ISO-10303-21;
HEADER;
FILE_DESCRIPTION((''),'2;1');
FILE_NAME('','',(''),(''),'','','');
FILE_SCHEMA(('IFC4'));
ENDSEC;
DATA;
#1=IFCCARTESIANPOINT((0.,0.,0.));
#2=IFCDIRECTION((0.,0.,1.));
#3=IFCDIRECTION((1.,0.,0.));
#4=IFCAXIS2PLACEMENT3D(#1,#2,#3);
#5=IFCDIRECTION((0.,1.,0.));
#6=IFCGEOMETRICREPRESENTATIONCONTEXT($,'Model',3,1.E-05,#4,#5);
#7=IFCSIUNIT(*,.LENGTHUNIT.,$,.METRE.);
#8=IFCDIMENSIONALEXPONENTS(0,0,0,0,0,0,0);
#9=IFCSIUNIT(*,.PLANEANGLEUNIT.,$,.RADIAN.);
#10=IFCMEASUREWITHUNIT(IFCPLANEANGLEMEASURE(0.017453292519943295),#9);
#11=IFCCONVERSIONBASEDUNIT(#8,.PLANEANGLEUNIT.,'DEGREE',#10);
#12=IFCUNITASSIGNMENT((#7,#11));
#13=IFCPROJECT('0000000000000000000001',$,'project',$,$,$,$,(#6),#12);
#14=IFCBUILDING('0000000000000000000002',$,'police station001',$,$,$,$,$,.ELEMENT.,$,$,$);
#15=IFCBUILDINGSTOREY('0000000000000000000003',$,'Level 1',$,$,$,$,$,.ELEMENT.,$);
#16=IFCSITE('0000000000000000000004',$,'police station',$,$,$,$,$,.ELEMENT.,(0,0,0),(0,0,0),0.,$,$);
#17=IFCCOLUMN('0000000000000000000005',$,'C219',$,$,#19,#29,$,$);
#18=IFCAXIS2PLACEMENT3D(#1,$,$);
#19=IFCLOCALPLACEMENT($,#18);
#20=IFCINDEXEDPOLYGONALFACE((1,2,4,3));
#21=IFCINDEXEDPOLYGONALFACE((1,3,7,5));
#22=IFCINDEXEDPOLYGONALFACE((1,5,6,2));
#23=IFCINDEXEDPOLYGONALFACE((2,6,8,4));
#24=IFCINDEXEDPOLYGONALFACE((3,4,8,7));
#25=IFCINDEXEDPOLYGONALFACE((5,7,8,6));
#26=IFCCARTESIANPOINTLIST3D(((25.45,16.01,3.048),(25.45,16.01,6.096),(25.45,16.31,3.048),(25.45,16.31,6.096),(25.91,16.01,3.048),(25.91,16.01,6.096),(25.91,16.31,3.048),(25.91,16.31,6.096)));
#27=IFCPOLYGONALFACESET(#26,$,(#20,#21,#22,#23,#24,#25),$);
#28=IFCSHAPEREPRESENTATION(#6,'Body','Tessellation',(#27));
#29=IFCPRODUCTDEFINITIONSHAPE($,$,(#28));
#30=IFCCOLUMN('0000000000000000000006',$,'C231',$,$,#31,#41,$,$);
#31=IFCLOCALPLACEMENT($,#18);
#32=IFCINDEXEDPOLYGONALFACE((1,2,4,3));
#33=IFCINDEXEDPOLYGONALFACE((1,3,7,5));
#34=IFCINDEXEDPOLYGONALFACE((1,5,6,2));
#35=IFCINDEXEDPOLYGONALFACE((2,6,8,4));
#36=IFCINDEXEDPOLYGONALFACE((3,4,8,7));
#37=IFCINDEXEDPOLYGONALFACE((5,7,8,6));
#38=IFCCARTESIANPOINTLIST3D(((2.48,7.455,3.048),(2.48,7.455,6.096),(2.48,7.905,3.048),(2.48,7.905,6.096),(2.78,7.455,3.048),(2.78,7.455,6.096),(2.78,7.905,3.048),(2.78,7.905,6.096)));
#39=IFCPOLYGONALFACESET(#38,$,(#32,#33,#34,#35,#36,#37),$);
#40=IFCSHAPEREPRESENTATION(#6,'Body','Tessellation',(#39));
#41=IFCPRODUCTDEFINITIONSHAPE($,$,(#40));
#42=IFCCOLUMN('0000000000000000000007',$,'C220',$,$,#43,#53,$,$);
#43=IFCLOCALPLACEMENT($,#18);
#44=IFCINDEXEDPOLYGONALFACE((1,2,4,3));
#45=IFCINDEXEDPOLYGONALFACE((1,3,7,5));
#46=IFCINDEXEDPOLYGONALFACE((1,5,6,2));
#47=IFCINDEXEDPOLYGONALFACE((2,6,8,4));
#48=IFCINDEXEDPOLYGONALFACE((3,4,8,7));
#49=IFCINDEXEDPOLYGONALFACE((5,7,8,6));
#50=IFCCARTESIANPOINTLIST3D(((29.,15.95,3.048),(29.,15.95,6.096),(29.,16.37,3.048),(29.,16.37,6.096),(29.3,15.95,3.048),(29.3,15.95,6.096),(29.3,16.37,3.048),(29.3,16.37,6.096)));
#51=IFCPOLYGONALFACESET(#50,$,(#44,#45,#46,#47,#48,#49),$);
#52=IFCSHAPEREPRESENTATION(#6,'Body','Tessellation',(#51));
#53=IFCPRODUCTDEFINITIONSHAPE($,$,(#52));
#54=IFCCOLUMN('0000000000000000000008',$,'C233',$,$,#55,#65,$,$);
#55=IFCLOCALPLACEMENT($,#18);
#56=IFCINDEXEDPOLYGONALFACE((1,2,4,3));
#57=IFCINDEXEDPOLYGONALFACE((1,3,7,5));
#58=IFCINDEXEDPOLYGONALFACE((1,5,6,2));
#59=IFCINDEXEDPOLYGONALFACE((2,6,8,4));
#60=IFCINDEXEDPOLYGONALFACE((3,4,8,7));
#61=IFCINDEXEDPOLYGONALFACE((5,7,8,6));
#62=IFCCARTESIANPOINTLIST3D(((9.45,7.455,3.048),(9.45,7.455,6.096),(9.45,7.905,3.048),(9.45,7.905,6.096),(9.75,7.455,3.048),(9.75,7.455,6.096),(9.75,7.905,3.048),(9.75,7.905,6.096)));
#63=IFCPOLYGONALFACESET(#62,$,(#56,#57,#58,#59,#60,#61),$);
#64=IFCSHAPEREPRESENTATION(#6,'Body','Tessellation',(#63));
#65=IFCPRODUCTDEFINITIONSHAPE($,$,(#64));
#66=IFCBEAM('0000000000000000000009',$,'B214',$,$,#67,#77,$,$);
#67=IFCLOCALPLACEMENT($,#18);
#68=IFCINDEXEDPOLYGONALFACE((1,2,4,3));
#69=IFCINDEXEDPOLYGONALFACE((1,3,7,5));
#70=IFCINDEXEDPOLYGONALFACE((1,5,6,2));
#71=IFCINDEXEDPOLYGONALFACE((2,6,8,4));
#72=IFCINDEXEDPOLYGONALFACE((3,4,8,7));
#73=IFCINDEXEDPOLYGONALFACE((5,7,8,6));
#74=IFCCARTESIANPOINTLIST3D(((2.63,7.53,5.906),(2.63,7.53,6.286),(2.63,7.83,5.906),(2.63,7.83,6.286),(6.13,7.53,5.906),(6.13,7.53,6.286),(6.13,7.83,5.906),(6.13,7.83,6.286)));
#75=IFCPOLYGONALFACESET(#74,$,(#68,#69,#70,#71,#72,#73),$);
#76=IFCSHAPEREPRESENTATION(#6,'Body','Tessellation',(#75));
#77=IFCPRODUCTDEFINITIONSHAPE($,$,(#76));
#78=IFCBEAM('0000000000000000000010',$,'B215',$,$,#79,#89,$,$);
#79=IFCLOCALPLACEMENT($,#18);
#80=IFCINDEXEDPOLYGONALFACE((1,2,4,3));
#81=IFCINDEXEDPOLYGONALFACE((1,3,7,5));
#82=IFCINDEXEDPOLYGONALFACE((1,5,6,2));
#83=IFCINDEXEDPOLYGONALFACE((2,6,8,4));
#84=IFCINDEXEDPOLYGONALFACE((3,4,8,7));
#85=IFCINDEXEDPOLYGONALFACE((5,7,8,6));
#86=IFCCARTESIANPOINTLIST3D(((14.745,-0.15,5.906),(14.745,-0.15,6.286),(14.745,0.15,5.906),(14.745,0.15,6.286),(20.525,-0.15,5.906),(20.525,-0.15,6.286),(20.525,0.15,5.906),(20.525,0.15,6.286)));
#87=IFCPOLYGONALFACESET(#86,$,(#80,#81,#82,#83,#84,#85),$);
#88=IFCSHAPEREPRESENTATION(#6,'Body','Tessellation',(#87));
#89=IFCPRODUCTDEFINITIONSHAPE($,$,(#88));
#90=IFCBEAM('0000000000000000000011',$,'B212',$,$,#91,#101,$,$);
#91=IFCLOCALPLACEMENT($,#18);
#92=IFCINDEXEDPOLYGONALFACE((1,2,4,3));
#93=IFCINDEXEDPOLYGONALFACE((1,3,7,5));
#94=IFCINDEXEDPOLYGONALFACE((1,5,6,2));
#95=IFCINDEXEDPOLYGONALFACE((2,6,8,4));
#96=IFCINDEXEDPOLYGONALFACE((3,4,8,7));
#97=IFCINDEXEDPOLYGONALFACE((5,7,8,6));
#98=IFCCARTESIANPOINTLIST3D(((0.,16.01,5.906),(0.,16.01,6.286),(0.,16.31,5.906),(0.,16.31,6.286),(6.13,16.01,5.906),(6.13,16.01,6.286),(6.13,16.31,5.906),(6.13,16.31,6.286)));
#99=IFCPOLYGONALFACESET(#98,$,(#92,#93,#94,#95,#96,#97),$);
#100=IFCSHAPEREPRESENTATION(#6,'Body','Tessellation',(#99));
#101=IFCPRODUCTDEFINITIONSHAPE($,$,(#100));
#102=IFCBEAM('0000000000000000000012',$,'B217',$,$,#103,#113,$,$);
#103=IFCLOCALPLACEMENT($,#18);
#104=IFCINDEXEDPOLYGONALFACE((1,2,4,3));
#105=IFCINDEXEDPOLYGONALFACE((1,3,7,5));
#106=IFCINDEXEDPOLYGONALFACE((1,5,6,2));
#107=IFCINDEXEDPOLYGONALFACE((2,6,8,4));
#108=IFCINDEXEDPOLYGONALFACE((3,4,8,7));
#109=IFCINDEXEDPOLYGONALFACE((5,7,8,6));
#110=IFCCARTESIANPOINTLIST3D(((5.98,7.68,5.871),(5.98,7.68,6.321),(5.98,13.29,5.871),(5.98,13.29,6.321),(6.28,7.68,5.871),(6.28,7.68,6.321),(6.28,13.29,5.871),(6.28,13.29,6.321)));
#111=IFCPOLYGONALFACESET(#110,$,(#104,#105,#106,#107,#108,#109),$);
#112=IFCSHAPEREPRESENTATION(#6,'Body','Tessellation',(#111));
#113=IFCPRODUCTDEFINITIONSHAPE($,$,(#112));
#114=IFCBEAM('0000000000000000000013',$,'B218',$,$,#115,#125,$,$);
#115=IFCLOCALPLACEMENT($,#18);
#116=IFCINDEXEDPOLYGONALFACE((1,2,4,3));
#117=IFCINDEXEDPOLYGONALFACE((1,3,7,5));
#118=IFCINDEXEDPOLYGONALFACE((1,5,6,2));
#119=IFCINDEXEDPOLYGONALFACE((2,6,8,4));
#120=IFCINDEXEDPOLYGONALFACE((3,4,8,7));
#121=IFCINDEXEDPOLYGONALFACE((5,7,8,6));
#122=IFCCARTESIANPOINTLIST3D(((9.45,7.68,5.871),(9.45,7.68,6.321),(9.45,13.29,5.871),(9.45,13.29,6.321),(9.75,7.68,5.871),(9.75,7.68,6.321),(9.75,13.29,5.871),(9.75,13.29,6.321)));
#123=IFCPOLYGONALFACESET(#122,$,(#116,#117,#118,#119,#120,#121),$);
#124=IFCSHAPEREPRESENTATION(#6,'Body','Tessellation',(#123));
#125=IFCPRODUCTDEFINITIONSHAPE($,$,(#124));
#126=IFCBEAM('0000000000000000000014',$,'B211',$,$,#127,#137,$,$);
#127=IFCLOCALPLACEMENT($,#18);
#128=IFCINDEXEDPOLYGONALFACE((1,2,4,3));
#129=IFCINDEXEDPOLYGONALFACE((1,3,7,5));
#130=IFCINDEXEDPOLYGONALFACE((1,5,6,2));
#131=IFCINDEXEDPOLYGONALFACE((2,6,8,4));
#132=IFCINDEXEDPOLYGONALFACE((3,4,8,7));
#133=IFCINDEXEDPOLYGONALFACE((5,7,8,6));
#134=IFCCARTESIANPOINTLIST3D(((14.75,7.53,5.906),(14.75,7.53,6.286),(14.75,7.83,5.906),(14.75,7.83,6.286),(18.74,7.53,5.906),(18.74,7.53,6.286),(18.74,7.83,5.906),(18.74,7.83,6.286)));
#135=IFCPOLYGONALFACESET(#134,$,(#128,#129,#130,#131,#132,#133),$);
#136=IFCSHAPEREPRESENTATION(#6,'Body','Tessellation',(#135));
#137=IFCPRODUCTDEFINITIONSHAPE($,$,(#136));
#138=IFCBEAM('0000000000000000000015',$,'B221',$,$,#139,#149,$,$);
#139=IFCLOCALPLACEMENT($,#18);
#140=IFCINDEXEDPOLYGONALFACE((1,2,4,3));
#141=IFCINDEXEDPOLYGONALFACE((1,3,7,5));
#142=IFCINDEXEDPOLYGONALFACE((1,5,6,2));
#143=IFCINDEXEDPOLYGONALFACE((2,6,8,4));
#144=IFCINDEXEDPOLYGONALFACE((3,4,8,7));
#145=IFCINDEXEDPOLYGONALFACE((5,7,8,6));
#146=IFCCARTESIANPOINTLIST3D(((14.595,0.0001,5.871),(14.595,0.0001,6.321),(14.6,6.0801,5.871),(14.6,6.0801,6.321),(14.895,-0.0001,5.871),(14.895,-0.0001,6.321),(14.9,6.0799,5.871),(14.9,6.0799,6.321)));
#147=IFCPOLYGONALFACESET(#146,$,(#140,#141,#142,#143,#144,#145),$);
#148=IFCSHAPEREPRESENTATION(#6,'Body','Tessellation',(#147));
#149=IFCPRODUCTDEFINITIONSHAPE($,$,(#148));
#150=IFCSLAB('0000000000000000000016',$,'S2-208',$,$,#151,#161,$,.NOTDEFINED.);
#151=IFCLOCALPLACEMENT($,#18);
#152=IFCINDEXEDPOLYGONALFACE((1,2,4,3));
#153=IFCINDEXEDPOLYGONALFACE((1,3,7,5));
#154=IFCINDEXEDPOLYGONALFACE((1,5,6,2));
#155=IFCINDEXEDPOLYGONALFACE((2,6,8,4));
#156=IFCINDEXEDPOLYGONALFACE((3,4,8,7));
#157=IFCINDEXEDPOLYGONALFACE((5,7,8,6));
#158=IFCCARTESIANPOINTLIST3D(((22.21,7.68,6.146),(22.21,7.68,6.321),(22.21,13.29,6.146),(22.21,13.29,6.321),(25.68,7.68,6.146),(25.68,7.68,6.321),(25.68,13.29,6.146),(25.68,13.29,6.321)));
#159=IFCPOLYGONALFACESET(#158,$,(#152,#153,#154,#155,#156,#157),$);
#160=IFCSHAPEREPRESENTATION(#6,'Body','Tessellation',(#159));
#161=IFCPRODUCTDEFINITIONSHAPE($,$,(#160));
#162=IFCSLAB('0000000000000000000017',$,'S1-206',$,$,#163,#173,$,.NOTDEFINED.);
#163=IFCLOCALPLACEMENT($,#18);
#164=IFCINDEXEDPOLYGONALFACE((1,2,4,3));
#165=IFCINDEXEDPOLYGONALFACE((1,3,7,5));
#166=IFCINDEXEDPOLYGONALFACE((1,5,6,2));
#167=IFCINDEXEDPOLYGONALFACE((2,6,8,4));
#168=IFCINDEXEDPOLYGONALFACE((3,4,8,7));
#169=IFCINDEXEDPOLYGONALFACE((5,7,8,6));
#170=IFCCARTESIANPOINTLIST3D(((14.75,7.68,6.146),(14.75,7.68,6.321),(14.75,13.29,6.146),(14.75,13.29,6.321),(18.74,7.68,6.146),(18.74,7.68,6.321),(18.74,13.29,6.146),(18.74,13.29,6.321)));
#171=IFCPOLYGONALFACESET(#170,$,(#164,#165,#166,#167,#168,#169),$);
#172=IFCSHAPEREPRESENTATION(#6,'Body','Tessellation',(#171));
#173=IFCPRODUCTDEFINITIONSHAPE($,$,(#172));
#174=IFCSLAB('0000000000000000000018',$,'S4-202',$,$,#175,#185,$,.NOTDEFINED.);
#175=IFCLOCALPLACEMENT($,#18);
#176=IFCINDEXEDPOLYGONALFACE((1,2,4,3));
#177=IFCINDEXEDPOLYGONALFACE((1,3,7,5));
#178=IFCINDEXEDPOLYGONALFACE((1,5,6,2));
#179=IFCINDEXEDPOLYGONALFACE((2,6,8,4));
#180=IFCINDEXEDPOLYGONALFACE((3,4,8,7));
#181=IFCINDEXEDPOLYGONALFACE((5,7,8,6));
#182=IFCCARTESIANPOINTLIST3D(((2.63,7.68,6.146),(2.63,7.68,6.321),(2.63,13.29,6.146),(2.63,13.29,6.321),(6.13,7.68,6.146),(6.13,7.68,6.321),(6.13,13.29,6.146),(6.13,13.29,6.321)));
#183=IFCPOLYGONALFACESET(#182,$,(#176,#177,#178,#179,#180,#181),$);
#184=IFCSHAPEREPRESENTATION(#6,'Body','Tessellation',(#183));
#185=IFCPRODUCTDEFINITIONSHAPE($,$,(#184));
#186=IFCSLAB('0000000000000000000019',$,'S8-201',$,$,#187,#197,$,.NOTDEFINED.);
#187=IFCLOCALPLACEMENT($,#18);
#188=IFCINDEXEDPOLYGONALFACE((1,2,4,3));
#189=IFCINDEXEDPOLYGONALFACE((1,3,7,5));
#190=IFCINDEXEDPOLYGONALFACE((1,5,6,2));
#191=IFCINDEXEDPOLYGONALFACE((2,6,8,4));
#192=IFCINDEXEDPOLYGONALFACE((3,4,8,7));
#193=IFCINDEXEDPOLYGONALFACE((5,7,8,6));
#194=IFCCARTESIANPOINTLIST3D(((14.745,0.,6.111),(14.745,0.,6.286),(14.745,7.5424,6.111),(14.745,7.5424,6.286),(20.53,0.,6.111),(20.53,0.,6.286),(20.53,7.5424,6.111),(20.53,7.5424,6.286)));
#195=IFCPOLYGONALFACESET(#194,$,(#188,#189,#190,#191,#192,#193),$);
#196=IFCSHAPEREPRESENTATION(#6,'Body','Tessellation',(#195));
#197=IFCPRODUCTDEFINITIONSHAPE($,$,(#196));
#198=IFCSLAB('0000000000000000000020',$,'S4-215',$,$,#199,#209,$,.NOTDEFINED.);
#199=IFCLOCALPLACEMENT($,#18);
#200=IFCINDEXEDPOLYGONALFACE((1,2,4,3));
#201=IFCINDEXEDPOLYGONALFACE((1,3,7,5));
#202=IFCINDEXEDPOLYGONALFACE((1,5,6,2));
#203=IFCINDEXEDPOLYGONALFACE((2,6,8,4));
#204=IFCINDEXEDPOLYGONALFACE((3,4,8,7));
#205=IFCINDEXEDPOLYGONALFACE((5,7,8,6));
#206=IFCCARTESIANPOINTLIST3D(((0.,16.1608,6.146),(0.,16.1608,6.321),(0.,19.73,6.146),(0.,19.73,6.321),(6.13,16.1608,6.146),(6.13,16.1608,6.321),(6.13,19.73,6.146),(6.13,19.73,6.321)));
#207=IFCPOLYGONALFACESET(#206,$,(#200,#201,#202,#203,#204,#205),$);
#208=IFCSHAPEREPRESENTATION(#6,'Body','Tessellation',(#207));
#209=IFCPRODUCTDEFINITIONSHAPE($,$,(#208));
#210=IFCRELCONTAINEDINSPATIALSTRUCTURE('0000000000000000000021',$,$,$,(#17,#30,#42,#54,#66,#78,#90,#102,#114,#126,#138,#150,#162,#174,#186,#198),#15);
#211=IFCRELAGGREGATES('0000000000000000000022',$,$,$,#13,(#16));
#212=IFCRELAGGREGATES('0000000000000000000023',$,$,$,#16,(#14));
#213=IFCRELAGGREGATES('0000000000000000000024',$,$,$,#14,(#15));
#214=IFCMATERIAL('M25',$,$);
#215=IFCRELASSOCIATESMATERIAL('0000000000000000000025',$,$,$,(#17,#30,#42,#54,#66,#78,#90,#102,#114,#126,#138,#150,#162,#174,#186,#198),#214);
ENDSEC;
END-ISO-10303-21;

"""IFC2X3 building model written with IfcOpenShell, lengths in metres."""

from ifc_helpers import new_model, entity, si_unit, converted_unit, direction, frame, frame_2d, origin_with_axes, place, context, project, spatial, rectangle, extrude, material, element, save


model = new_model("IFC2X3")

# Units and contexts
model_context = context("Model", 3, precision=1e-05, world=origin_with_axes(), true_north=direction((0.0, 1.0, 0.0)))
ifc_project = project(units=[si_unit("LENGTHUNIT", "METRE"), converted_unit("PLANEANGLEUNIT", "DEGREE", entity("IfcPlaneAngleMeasure", 0.017453292519943295), si_unit("PLANEANGLEUNIT", "RADIAN"), dimensions=[0, 0, 0, 0, 0, 0, 0])], contexts=[model_context])

# Site, building, storey
site = spatial("IfcSite", under=ifc_project, Name="police station", CompositionType="ELEMENT", RefLatitude=(0, 0, 0), RefLongitude=(0, 0, 0), RefElevation=0.0)
building = spatial("IfcBuilding", under=site, Name="police station001", CompositionType="ELEMENT")
storey = spatial("IfcBuildingStorey", under=building, Name="Level 1", CompositionType="ELEMENT")

# Columns
ifc_material = material(Name="M25")
placement = place(None, origin_with_axes())
element("IfcColumn", 1, at=placement, inside=storey, material=ifc_material, Name="C219", context=model_context, shape_type="SweptSolid", body=[
    extrude(rectangle(XDim=0.46, YDim=0.3, at=frame_2d((0.0, 0.0), x_axis=(1.0, 0.0, 0.0))), frame((25.68, 16.16, 3.048), z_axis=(0.0, 0.0, 1.0), x_axis=(1.0, 0.0, 0.0)), (0.0, 0.0, 1.0), 3.048),
])
element("IfcColumn", 2, at=placement, inside=storey, material=ifc_material, Name="C231", context=model_context, shape_type="SweptSolid", body=[
    extrude(rectangle(XDim=0.3, YDim=0.45, at=frame_2d((0.0, 0.0), x_axis=(1.0, 0.0, 0.0))), frame((2.63, 7.68, 3.048), z_axis=(0.0, 0.0, 1.0), x_axis=(1.0, 0.0, 0.0)), (0.0, 0.0, 1.0), 3.048),
])
element("IfcColumn", 3, at=placement, inside=storey, material=ifc_material, Name="C220", context=model_context, shape_type="SweptSolid", body=[
    extrude(rectangle(XDim=0.3, YDim=0.42, at=frame_2d((0.0, 0.0), x_axis=(1.0, 0.0, 0.0))), frame((29.15, 16.16, 3.048), z_axis=(0.0, 0.0, 1.0), x_axis=(1.0, 0.0, 0.0)), (0.0, 0.0, 1.0), 3.048),
])
element("IfcColumn", 4, at=placement, inside=storey, material=ifc_material, Name="C233", context=model_context, shape_type="SweptSolid", body=[
    extrude(rectangle(XDim=0.3, YDim=0.45, at=frame_2d((0.0, 0.0), x_axis=(1.0, 0.0, 0.0))), frame((9.6, 7.68, 3.048), z_axis=(0.0, 0.0, 1.0), x_axis=(1.0, 0.0, 0.0)), (0.0, 0.0, 1.0), 3.048),
])

# Beams
element("IfcBeam", 5, at=placement, inside=storey, material=ifc_material, Name="B214", context=model_context, shape_type="SweptSolid", body=[
    extrude(rectangle(XDim=0.3, YDim=0.38, at=frame_2d((0.0, 0.0), x_axis=(0.0, 1.0, 0.0))), frame((2.63, 7.68, 6.096), z_axis=(1.0, 0.0, 0.0), x_axis=(0.0, 0.0, -1.0)), (0.0, 0.0, 1.0), 3.5),
])
element("IfcBeam", 6, at=placement, inside=storey, material=ifc_material, Name="B215", context=model_context, shape_type="SweptSolid", body=[
    extrude(rectangle(XDim=0.3, YDim=0.38, at=frame_2d((0.0, 0.0), x_axis=(0.0, 1.0, 0.0))), frame((14.745, 0.0, 6.096), z_axis=(1.0, 0.0, 0.0), x_axis=(0.0, 0.0, -1.0)), (0.0, 0.0, 1.0), 5.78),
])
element("IfcBeam", 7, at=placement, inside=storey, material=ifc_material, Name="B212", context=model_context, shape_type="SweptSolid", body=[
    extrude(rectangle(XDim=0.3, YDim=0.38, at=frame_2d((0.0, 0.0), x_axis=(0.0, 1.0, 0.0))), frame((6.13, 16.16, 6.096), z_axis=(-1.0, 0.0, 0.0), x_axis=(0.0, 0.0, -1.0)), (0.0, 0.0, 1.0), 6.13),
])
element("IfcBeam", 8, at=placement, inside=storey, material=ifc_material, Name="B217", context=model_context, shape_type="SweptSolid", body=[
    extrude(rectangle(XDim=0.3, YDim=0.45, at=frame_2d((0.0, 0.0), x_axis=(0.0, 1.0, 0.0))), frame((6.13, 7.68, 6.096), z_axis=(0.0, 1.0, 0.0), x_axis=(0.0, 0.0, -1.0)), (0.0, 0.0, 1.0), 5.61),
])
element("IfcBeam", 9, at=placement, inside=storey, material=ifc_material, Name="B218", context=model_context, shape_type="SweptSolid", body=[
    extrude(rectangle(XDim=0.3, YDim=0.45, at=frame_2d((0.0, 0.0), x_axis=(0.0, 1.0, 0.0))), frame((9.6, 7.68, 6.096), z_axis=(0.0, 1.0, 0.0), x_axis=(0.0, 0.0, -1.0)), (0.0, 0.0, 1.0), 5.61),
])
element("IfcBeam", 10, at=placement, inside=storey, material=ifc_material, Name="B211", context=model_context, shape_type="SweptSolid", body=[
    extrude(rectangle(XDim=0.3, YDim=0.38, at=frame_2d((0.0, 0.0), x_axis=(0.0, 1.0, 0.0))), frame((14.75, 7.68, 6.096), z_axis=(1.0, 0.0, 0.0), x_axis=(0.0, 0.0, -1.0)), (0.0, 0.0, 1.0), 3.99),
])
element("IfcBeam", 11, at=placement, inside=storey, material=ifc_material, Name="B221", context=model_context, shape_type="SweptSolid", body=[
    extrude(rectangle(XDim=0.3, YDim=0.45, at=frame_2d((0.0, 0.0), x_axis=(0.0, 1.0, 0.0))), frame((14.745, 0.0, 6.096), z_axis=(0.000822, 1.0, 0.0), x_axis=(0.0, 0.0, -1.0)), (0.0, 0.0, 1.0), 6.08),
])

# Slabs
element("IfcSlab", 12, at=placement, inside=storey, material=ifc_material, Name="S2-208", PredefinedType="NOTDEFINED", context=model_context, shape_type="SweptSolid", body=[
    extrude(rectangle(XDim=3.47, YDim=5.61, at=frame_2d((0.0, 0.0), x_axis=(1.0, 0.0, 0.0))), frame((23.945, 10.485, 6.146), z_axis=(0.0, 0.0, 1.0), x_axis=(1.0, 0.0, 0.0)), (0.0, 0.0, 1.0), 0.175),
])
element("IfcSlab", 13, at=placement, inside=storey, material=ifc_material, Name="S1-206", PredefinedType="NOTDEFINED", context=model_context, shape_type="SweptSolid", body=[
    extrude(rectangle(XDim=3.99, YDim=5.61, at=frame_2d((0.0, 0.0), x_axis=(1.0, 0.0, 0.0))), frame((16.745, 10.485, 6.146), z_axis=(0.0, 0.0, 1.0), x_axis=(1.0, 0.0, 0.0)), (0.0, 0.0, 1.0), 0.175),
])
element("IfcSlab", 14, at=placement, inside=storey, material=ifc_material, Name="S4-202", PredefinedType="NOTDEFINED", context=model_context, shape_type="SweptSolid", body=[
    extrude(rectangle(XDim=3.5, YDim=5.61, at=frame_2d((0.0, 0.0), x_axis=(1.0, 0.0, 0.0))), frame((4.38, 10.485, 6.146), z_axis=(0.0, 0.0, 1.0), x_axis=(1.0, 0.0, 0.0)), (0.0, 0.0, 1.0), 0.175),
])
element("IfcSlab", 15, at=placement, inside=storey, material=ifc_material, Name="S8-201", PredefinedType="NOTDEFINED", context=model_context, shape_type="SweptSolid", body=[
    extrude(rectangle(XDim=5.785, YDim=7.5424, at=frame_2d((0.0, 0.0), x_axis=(1.0, 0.0, 0.0))), frame((17.6375, 3.7712, 6.111), z_axis=(0.0, 0.0, 1.0), x_axis=(1.0, 0.0, 0.0)), (0.0, 0.0, 1.0), 0.175),
])
element("IfcSlab", 16, at=placement, inside=storey, material=ifc_material, Name="S4-215", PredefinedType="NOTDEFINED", context=model_context, shape_type="SweptSolid", body=[
    extrude(rectangle(XDim=6.13, YDim=3.5692, at=frame_2d((0.0, 0.0), x_axis=(1.0, 0.0, 0.0))), frame((3.065, 17.9454, 6.146), z_axis=(0.0, 0.0, 1.0), x_axis=(1.0, 0.0, 0.0)), (0.0, 0.0, 1.0), 0.175),
])

save(model, "model.ifc")
